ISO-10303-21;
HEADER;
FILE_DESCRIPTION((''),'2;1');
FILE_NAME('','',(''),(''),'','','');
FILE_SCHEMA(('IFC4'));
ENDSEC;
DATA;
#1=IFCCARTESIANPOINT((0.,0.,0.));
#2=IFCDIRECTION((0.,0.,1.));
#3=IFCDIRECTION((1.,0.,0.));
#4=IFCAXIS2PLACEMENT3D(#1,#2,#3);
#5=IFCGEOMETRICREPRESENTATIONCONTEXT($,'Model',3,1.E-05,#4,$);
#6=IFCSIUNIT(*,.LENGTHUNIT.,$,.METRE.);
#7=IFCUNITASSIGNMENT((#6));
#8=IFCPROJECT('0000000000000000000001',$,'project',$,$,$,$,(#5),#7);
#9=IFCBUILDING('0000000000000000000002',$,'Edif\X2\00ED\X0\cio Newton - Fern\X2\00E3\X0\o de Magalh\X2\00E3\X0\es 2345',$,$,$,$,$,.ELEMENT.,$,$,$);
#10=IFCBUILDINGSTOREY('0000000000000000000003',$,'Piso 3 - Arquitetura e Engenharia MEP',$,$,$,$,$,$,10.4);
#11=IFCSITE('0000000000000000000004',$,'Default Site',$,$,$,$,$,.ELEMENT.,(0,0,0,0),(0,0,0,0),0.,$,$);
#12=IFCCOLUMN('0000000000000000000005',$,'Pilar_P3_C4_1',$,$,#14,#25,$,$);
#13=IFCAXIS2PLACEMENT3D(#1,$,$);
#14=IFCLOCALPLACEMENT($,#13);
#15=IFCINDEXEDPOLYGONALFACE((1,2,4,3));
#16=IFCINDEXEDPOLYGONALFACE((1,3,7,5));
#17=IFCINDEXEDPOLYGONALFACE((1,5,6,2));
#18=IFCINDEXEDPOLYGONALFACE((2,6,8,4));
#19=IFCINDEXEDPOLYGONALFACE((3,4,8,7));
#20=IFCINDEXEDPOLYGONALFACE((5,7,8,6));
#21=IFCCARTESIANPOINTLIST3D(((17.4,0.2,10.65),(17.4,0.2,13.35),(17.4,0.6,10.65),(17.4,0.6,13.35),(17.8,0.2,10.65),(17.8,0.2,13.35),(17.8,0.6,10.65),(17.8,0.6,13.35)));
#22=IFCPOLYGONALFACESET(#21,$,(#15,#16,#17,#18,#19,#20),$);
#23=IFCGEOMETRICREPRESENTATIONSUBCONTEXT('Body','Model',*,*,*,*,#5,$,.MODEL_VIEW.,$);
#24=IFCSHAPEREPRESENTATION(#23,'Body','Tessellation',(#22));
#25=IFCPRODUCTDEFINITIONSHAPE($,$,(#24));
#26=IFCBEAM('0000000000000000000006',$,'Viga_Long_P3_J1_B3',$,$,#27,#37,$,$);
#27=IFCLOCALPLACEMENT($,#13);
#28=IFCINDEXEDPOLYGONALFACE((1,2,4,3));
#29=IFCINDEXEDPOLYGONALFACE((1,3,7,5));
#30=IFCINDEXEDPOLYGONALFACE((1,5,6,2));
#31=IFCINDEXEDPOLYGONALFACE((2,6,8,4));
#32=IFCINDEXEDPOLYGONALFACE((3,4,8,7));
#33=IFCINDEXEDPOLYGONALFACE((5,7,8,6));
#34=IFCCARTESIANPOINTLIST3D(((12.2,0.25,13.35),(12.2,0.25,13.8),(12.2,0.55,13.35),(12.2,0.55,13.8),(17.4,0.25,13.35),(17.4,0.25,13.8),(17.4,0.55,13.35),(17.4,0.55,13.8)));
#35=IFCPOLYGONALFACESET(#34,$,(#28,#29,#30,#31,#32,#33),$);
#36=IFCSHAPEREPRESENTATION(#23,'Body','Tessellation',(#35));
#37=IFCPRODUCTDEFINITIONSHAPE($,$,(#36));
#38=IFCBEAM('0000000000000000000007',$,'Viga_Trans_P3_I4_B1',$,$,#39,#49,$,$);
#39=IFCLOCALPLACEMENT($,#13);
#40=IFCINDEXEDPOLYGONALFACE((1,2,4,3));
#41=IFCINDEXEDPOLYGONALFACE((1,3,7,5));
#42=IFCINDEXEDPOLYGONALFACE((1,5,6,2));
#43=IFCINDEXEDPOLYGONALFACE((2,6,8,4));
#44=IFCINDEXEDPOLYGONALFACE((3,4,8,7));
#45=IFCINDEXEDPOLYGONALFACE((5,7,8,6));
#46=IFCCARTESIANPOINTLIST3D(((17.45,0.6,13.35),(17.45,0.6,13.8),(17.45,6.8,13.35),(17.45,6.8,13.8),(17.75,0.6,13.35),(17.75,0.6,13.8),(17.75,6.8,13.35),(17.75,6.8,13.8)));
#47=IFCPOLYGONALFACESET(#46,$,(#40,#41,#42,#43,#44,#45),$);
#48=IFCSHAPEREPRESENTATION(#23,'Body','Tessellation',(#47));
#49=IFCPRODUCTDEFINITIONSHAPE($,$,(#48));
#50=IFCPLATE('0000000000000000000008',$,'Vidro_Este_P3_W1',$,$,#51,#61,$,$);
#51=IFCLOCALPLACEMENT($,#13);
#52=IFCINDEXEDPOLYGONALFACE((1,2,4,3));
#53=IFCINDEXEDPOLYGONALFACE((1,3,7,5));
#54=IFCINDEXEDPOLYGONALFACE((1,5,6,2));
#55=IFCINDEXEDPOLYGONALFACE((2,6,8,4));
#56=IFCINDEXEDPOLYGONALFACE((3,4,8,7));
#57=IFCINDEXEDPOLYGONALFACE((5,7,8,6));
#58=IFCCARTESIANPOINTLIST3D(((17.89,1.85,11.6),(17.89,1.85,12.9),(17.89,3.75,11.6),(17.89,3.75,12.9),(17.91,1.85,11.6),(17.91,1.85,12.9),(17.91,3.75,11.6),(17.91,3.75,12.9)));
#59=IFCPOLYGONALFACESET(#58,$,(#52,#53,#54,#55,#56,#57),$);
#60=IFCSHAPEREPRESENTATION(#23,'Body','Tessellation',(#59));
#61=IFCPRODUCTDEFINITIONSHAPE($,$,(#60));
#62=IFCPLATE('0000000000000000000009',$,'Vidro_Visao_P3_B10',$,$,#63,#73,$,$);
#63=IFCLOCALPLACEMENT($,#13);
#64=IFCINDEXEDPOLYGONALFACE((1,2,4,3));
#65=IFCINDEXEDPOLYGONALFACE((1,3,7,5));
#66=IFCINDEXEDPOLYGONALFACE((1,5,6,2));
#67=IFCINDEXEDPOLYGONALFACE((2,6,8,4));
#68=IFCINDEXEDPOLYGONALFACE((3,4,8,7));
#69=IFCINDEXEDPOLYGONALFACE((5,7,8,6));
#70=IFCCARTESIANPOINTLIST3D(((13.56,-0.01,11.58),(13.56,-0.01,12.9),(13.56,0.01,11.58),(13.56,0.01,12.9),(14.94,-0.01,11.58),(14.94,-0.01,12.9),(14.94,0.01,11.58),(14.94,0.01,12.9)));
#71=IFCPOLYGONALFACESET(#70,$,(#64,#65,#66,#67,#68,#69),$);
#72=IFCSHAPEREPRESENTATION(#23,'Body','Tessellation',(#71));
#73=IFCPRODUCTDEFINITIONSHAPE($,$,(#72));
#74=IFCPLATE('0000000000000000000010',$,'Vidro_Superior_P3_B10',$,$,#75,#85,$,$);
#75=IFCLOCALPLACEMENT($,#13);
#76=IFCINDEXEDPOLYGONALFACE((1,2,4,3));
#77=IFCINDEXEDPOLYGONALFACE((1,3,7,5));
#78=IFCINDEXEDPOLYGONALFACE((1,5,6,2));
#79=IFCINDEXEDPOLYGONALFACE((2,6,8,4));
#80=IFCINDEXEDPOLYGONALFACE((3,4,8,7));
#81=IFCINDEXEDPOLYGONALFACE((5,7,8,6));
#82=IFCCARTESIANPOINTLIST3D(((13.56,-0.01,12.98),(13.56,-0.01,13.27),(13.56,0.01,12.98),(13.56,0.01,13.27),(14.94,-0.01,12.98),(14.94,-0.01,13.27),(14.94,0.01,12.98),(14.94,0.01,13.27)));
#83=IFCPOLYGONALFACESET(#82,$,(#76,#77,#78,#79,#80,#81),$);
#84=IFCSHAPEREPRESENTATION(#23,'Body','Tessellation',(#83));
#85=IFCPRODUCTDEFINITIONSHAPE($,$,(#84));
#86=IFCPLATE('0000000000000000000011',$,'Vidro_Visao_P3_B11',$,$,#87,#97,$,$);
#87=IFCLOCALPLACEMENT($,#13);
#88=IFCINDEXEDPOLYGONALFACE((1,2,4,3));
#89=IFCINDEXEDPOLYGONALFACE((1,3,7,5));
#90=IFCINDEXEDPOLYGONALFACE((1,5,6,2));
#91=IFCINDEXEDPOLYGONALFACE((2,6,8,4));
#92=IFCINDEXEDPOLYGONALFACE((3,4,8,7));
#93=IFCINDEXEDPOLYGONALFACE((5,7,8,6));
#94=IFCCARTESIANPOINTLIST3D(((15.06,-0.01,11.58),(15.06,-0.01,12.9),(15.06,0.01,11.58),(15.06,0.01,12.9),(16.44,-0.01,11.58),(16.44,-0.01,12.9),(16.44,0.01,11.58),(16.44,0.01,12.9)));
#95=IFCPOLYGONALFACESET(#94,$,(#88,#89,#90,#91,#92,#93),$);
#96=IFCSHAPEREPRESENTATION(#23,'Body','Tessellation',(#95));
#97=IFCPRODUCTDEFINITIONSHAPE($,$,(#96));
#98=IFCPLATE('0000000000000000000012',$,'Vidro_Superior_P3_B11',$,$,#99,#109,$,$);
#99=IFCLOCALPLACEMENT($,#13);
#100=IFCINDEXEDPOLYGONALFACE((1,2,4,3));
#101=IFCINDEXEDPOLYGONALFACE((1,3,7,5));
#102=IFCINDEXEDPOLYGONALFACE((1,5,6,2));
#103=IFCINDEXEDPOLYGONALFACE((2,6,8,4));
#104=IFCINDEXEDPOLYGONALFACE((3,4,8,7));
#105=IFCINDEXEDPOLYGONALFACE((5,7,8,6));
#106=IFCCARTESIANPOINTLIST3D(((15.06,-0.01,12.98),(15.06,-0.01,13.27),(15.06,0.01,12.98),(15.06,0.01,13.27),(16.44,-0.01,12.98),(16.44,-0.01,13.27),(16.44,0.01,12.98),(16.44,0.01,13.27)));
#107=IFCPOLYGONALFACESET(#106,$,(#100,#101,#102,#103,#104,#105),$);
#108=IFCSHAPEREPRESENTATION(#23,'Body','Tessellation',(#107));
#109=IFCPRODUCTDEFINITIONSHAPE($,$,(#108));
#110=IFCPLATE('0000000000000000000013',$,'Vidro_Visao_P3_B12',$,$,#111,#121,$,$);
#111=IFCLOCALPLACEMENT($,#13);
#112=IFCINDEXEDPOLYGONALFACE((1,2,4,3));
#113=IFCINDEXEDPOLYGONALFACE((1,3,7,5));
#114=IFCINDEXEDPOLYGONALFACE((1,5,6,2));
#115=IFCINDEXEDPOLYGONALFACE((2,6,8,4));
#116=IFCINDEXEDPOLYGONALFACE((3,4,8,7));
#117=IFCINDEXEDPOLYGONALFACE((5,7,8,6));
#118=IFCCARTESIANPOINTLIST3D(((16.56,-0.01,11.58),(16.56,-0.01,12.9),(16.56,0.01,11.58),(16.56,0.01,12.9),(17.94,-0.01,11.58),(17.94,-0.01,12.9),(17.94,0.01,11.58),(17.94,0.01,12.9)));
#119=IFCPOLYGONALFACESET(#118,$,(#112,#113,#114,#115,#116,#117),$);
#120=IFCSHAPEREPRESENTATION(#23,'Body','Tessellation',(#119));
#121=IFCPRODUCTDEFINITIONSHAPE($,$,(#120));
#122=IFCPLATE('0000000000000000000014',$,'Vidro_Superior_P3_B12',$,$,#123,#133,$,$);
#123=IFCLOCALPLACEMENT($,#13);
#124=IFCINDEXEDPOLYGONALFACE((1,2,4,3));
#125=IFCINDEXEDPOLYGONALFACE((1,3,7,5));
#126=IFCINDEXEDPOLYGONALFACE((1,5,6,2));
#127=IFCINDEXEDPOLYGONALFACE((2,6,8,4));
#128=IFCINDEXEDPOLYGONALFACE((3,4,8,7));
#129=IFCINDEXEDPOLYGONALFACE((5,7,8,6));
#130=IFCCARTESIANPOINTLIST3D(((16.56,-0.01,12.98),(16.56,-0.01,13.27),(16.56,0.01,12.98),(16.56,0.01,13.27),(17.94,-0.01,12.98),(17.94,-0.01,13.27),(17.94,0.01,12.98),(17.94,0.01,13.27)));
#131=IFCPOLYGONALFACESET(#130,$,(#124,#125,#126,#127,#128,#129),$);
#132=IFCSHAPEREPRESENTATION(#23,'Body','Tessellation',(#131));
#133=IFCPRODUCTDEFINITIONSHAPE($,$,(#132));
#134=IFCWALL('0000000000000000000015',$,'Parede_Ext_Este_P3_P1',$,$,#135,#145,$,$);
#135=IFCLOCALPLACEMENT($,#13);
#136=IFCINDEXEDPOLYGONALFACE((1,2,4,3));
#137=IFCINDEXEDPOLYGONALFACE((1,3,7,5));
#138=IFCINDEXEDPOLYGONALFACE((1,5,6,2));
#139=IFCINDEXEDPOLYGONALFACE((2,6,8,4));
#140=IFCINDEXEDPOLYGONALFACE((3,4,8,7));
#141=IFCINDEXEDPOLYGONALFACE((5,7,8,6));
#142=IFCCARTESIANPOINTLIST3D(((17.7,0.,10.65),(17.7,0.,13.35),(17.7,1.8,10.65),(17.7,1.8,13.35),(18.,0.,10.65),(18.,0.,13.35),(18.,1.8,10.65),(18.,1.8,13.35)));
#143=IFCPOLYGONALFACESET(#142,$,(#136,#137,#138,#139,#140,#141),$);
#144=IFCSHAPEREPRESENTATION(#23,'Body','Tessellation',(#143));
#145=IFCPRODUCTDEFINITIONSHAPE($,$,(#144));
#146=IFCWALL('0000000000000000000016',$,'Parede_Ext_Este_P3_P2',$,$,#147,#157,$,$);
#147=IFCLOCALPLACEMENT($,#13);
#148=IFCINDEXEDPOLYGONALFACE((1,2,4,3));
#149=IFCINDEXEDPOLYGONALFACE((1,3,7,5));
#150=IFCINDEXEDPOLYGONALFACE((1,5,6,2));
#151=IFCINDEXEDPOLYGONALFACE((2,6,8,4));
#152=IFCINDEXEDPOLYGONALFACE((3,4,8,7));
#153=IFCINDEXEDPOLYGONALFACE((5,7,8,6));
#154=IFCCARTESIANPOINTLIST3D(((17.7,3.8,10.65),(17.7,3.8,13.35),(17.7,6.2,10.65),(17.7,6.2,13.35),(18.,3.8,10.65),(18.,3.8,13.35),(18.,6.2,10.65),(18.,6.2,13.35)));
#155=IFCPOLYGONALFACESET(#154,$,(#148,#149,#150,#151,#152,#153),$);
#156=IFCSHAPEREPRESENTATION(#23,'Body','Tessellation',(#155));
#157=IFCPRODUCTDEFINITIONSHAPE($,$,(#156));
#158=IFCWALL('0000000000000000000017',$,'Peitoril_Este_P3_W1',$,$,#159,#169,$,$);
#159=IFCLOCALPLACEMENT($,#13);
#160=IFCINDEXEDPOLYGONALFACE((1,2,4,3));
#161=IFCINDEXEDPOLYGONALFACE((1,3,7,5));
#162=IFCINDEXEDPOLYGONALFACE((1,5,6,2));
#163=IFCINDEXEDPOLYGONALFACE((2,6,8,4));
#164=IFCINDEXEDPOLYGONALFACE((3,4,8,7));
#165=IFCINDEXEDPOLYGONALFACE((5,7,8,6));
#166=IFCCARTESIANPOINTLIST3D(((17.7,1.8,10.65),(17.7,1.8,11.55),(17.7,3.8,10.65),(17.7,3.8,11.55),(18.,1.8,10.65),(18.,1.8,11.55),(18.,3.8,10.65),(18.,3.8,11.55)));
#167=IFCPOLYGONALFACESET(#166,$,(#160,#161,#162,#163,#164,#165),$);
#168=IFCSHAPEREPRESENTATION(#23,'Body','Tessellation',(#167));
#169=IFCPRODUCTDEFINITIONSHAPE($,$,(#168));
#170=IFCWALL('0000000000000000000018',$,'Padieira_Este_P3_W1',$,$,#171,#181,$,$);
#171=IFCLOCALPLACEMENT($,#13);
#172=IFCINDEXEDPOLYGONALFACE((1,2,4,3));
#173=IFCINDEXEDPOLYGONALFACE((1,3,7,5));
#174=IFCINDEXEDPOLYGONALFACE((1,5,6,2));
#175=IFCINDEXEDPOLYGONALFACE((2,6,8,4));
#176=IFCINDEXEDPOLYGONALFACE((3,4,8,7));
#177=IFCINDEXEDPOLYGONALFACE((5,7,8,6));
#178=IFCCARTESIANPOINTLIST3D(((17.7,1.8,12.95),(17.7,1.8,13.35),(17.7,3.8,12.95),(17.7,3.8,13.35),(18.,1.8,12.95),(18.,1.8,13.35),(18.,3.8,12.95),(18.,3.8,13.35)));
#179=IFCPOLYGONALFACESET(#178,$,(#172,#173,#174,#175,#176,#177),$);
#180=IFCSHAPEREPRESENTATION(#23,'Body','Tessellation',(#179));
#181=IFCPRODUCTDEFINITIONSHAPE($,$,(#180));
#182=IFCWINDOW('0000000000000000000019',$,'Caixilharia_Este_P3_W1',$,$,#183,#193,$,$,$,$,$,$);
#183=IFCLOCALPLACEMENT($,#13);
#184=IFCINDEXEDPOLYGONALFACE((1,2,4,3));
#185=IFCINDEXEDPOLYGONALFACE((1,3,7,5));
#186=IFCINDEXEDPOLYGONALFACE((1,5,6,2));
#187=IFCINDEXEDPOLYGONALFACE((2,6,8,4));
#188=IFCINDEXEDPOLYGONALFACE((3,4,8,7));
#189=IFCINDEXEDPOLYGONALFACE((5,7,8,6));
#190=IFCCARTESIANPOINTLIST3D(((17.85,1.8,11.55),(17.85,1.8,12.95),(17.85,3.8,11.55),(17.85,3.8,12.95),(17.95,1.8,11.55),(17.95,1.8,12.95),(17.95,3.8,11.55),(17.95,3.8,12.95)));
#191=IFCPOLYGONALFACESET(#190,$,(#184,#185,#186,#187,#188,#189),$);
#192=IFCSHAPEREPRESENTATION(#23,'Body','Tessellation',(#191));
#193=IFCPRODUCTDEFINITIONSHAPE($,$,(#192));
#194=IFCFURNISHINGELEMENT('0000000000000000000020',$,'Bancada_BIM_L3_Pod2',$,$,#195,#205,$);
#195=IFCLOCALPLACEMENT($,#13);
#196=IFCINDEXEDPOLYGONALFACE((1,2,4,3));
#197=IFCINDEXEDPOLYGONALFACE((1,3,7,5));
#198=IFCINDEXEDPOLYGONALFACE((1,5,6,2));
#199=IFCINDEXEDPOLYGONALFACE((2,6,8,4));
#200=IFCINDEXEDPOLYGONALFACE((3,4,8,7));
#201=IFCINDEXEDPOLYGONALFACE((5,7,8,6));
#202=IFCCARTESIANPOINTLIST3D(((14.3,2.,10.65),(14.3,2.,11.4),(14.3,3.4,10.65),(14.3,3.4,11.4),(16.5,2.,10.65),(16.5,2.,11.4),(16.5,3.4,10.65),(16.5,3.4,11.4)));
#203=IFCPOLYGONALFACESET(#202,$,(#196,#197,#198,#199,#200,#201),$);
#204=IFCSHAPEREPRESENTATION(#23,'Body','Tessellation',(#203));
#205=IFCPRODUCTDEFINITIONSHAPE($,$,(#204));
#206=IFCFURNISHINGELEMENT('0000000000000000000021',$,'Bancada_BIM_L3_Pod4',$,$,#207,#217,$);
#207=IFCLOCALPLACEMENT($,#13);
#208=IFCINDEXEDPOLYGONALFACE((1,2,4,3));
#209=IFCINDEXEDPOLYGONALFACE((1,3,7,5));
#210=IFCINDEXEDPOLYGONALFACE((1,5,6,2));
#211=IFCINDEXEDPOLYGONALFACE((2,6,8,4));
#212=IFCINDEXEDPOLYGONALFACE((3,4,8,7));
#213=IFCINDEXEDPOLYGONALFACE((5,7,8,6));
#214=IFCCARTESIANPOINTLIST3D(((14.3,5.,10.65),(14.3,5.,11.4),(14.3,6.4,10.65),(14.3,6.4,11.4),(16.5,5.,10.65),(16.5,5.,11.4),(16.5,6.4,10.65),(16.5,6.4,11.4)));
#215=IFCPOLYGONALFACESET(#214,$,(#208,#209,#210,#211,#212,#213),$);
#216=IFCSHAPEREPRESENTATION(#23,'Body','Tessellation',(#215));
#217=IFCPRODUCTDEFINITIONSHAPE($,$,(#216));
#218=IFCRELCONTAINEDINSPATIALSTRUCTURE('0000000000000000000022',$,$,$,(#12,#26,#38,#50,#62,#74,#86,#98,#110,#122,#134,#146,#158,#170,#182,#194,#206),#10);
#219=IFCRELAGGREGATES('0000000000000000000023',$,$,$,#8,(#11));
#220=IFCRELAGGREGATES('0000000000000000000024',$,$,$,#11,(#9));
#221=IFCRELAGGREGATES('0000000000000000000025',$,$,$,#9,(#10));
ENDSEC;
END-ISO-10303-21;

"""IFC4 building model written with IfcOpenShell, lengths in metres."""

from ifc_helpers import new_model, si_unit, frame, frame_2d, origin_with_axes, place, context, subcontext, project, spatial, rectangle, extrude, element, save


model = new_model("IFC4")

# Units and contexts
model_context = context("Model", 3, precision=1e-05, world=origin_with_axes())
body_context = subcontext(model_context, "Body", "Model", "MODEL_VIEW")
ifc_project = project(units=[si_unit("LENGTHUNIT", "METRE")], contexts=[model_context])

# Site, building, storey
site = spatial("IfcSite", under=ifc_project, Name="Default Site", CompositionType="ELEMENT", RefLatitude=(0, 0, 0, 0), RefLongitude=(0, 0, 0, 0), RefElevation=0.0)
building = spatial("IfcBuilding", under=site, Name="Edifício Newton - Fernão de Magalhães 2345", CompositionType="ELEMENT")
storey = spatial("IfcBuildingStorey", under=building, Name="Piso 3 - Arquitetura e Engenharia MEP", Elevation=10.4)

# Column
column_placement = place(None, frame((17.4, 0.2, 10.65), z_axis=(0.0, 0.0, 1.0), x_axis=(1.0, 0.0, 0.0)))
element("IfcColumn", 1, at=column_placement, inside=storey, Name="Pilar_P3_C4_1", context=body_context, shape_type="SweptSolid", body=[
    extrude(rectangle(XDim=0.4, YDim=0.4, at=frame_2d((0.2, 0.2))), origin_with_axes(), (0.0, 0.0, 1.0), 2.7),
])

# Beams
beam_1_placement = place(None, frame((12.2, 0.25, 13.35), z_axis=(0.0, 0.0, 1.0), x_axis=(1.0, 0.0, 0.0)))
element("IfcBeam", 2, at=beam_1_placement, inside=storey, Name="Viga_Long_P3_J1_B3", context=body_context, shape_type="SweptSolid", body=[
    extrude(rectangle(XDim=5.2, YDim=0.3, at=frame_2d((2.6, 0.15))), origin_with_axes(), (0.0, 0.0, 1.0), 0.45),
])
beam_2_placement = place(None, frame((17.45, 0.6, 13.35), z_axis=(0.0, 0.0, 1.0), x_axis=(1.0, 0.0, 0.0)))
element("IfcBeam", 3, at=beam_2_placement, inside=storey, Name="Viga_Trans_P3_I4_B1", context=body_context, shape_type="SweptSolid", body=[
    extrude(rectangle(XDim=0.3, YDim=6.2, at=frame_2d((0.15, 3.1))), origin_with_axes(), (0.0, 0.0, 1.0), 0.45),
])

# Plates
plate_1_placement = place(None, frame((17.89, 1.85, 11.6), z_axis=(0.0, 0.0, 1.0), x_axis=(1.0, 0.0, 0.0)))
element("IfcPlate", 4, at=plate_1_placement, inside=storey, Name="Vidro_Este_P3_W1", context=body_context, shape_type="SweptSolid", body=[
    extrude(rectangle(XDim=0.02, YDim=1.9, at=frame_2d((0.01, 0.95))), origin_with_axes(), (0.0, 0.0, 1.0), 1.3),
])
plate_2_placement = place(None, frame((13.56, -0.01, 11.58), z_axis=(0.0, 0.0, 1.0), x_axis=(1.0, 0.0, 0.0)))
element("IfcPlate", 5, at=plate_2_placement, inside=storey, Name="Vidro_Visao_P3_B10", context=body_context, shape_type="SweptSolid", body=[
    extrude(rectangle(XDim=1.38, YDim=0.02, at=frame_2d((0.69, 0.01))), origin_with_axes(), (0.0, 0.0, 1.0), 1.32),
])
plate_3_placement = place(None, frame((13.56, -0.01, 12.98), z_axis=(0.0, 0.0, 1.0), x_axis=(1.0, 0.0, 0.0)))
element("IfcPlate", 6, at=plate_3_placement, inside=storey, Name="Vidro_Superior_P3_B10", context=body_context, shape_type="SweptSolid", body=[
    extrude(rectangle(XDim=1.38, YDim=0.02, at=frame_2d((0.69, 0.01))), origin_with_axes(), (0.0, 0.0, 1.0), 0.29),
])
plate_4_placement = place(None, frame((15.06, -0.01, 11.58), z_axis=(0.0, 0.0, 1.0), x_axis=(1.0, 0.0, 0.0)))
element("IfcPlate", 7, at=plate_4_placement, inside=storey, Name="Vidro_Visao_P3_B11", context=body_context, shape_type="SweptSolid", body=[
    extrude(rectangle(XDim=1.38, YDim=0.02, at=frame_2d((0.69, 0.01))), origin_with_axes(), (0.0, 0.0, 1.0), 1.32),
])
plate_5_placement = place(None, frame((15.06, -0.01, 12.98), z_axis=(0.0, 0.0, 1.0), x_axis=(1.0, 0.0, 0.0)))
element("IfcPlate", 8, at=plate_5_placement, inside=storey, Name="Vidro_Superior_P3_B11", context=body_context, shape_type="SweptSolid", body=[
    extrude(rectangle(XDim=1.38, YDim=0.02, at=frame_2d((0.69, 0.01))), origin_with_axes(), (0.0, 0.0, 1.0), 0.29),
])
plate_6_placement = place(None, frame((16.56, -0.01, 11.58), z_axis=(0.0, 0.0, 1.0), x_axis=(1.0, 0.0, 0.0)))
element("IfcPlate", 9, at=plate_6_placement, inside=storey, Name="Vidro_Visao_P3_B12", context=body_context, shape_type="SweptSolid", body=[
    extrude(rectangle(XDim=1.38, YDim=0.02, at=frame_2d((0.69, 0.01))), origin_with_axes(), (0.0, 0.0, 1.0), 1.32),
])
plate_7_placement = place(None, frame((16.56, -0.01, 12.98), z_axis=(0.0, 0.0, 1.0), x_axis=(1.0, 0.0, 0.0)))
element("IfcPlate", 10, at=plate_7_placement, inside=storey, Name="Vidro_Superior_P3_B12", context=body_context, shape_type="SweptSolid", body=[
    extrude(rectangle(XDim=1.38, YDim=0.02, at=frame_2d((0.69, 0.01))), origin_with_axes(), (0.0, 0.0, 1.0), 0.29),
])

# Walls
wall_1_placement = place(None, frame((17.7, 0.0, 10.65), z_axis=(0.0, 0.0, 1.0), x_axis=(1.0, 0.0, 0.0)))
element("IfcWall", 11, at=wall_1_placement, inside=storey, Name="Parede_Ext_Este_P3_P1", context=body_context, shape_type="SweptSolid", body=[
    extrude(rectangle(XDim=0.3, YDim=1.8, at=frame_2d((0.15, 0.9))), origin_with_axes(), (0.0, 0.0, 1.0), 2.7),
])
wall_2_placement = place(None, frame((17.7, 3.8, 10.65), z_axis=(0.0, 0.0, 1.0), x_axis=(1.0, 0.0, 0.0)))
element("IfcWall", 12, at=wall_2_placement, inside=storey, Name="Parede_Ext_Este_P3_P2", context=body_context, shape_type="SweptSolid", body=[
    extrude(rectangle(XDim=0.3, YDim=2.4, at=frame_2d((0.15, 1.2))), origin_with_axes(), (0.0, 0.0, 1.0), 2.7),
])
wall_3_placement = place(None, frame((17.7, 1.8, 10.65), z_axis=(0.0, 0.0, 1.0), x_axis=(1.0, 0.0, 0.0)))
element("IfcWall", 13, at=wall_3_placement, inside=storey, Name="Peitoril_Este_P3_W1", context=body_context, shape_type="SweptSolid", body=[
    extrude(rectangle(XDim=0.3, YDim=2.0, at=frame_2d((0.15, 1.0))), origin_with_axes(), (0.0, 0.0, 1.0), 0.9),
])
wall_4_placement = place(None, frame((17.7, 1.8, 12.95), z_axis=(0.0, 0.0, 1.0), x_axis=(1.0, 0.0, 0.0)))
element("IfcWall", 14, at=wall_4_placement, inside=storey, Name="Padieira_Este_P3_W1", context=body_context, shape_type="SweptSolid", body=[
    extrude(rectangle(XDim=0.3, YDim=2.0, at=frame_2d((0.15, 1.0))), origin_with_axes(), (0.0, 0.0, 1.0), 0.4),
])

# Window
window_placement = place(None, frame((17.85, 1.8, 11.55), z_axis=(0.0, 0.0, 1.0), x_axis=(1.0, 0.0, 0.0)))
element("IfcWindow", 15, at=window_placement, inside=storey, Name="Caixilharia_Este_P3_W1", context=body_context, shape_type="SweptSolid", body=[
    extrude(rectangle(XDim=0.1, YDim=2.0, at=frame_2d((0.05, 1.0))), origin_with_axes(), (0.0, 0.0, 1.0), 1.4),
])

# Furnishing elements
for number, where, z_axis, x_axis, name in (
    (16, (14.3, 2.0, 10.65), (0.0, 0.0, 1.0), (1.0, 0.0, 0.0), "Bancada_BIM_L3_Pod2"),
    (17, (14.3, 5.0, 10.65), (0.0, 0.0, 1.0), (1.0, 0.0, 0.0), "Bancada_BIM_L3_Pod4"),
):
    element("IfcFurnishingElement", number, at=place(None, frame(where, z_axis=z_axis, x_axis=x_axis)), inside=storey, Name=name, context=body_context, shape_type="SweptSolid", body=[
        extrude(rectangle(XDim=2.2, YDim=1.4, at=frame_2d((1.1, 0.7))), origin_with_axes(), (0.0, 0.0, 1.0), 0.75),
    ])

save(model, "model.ifc")
